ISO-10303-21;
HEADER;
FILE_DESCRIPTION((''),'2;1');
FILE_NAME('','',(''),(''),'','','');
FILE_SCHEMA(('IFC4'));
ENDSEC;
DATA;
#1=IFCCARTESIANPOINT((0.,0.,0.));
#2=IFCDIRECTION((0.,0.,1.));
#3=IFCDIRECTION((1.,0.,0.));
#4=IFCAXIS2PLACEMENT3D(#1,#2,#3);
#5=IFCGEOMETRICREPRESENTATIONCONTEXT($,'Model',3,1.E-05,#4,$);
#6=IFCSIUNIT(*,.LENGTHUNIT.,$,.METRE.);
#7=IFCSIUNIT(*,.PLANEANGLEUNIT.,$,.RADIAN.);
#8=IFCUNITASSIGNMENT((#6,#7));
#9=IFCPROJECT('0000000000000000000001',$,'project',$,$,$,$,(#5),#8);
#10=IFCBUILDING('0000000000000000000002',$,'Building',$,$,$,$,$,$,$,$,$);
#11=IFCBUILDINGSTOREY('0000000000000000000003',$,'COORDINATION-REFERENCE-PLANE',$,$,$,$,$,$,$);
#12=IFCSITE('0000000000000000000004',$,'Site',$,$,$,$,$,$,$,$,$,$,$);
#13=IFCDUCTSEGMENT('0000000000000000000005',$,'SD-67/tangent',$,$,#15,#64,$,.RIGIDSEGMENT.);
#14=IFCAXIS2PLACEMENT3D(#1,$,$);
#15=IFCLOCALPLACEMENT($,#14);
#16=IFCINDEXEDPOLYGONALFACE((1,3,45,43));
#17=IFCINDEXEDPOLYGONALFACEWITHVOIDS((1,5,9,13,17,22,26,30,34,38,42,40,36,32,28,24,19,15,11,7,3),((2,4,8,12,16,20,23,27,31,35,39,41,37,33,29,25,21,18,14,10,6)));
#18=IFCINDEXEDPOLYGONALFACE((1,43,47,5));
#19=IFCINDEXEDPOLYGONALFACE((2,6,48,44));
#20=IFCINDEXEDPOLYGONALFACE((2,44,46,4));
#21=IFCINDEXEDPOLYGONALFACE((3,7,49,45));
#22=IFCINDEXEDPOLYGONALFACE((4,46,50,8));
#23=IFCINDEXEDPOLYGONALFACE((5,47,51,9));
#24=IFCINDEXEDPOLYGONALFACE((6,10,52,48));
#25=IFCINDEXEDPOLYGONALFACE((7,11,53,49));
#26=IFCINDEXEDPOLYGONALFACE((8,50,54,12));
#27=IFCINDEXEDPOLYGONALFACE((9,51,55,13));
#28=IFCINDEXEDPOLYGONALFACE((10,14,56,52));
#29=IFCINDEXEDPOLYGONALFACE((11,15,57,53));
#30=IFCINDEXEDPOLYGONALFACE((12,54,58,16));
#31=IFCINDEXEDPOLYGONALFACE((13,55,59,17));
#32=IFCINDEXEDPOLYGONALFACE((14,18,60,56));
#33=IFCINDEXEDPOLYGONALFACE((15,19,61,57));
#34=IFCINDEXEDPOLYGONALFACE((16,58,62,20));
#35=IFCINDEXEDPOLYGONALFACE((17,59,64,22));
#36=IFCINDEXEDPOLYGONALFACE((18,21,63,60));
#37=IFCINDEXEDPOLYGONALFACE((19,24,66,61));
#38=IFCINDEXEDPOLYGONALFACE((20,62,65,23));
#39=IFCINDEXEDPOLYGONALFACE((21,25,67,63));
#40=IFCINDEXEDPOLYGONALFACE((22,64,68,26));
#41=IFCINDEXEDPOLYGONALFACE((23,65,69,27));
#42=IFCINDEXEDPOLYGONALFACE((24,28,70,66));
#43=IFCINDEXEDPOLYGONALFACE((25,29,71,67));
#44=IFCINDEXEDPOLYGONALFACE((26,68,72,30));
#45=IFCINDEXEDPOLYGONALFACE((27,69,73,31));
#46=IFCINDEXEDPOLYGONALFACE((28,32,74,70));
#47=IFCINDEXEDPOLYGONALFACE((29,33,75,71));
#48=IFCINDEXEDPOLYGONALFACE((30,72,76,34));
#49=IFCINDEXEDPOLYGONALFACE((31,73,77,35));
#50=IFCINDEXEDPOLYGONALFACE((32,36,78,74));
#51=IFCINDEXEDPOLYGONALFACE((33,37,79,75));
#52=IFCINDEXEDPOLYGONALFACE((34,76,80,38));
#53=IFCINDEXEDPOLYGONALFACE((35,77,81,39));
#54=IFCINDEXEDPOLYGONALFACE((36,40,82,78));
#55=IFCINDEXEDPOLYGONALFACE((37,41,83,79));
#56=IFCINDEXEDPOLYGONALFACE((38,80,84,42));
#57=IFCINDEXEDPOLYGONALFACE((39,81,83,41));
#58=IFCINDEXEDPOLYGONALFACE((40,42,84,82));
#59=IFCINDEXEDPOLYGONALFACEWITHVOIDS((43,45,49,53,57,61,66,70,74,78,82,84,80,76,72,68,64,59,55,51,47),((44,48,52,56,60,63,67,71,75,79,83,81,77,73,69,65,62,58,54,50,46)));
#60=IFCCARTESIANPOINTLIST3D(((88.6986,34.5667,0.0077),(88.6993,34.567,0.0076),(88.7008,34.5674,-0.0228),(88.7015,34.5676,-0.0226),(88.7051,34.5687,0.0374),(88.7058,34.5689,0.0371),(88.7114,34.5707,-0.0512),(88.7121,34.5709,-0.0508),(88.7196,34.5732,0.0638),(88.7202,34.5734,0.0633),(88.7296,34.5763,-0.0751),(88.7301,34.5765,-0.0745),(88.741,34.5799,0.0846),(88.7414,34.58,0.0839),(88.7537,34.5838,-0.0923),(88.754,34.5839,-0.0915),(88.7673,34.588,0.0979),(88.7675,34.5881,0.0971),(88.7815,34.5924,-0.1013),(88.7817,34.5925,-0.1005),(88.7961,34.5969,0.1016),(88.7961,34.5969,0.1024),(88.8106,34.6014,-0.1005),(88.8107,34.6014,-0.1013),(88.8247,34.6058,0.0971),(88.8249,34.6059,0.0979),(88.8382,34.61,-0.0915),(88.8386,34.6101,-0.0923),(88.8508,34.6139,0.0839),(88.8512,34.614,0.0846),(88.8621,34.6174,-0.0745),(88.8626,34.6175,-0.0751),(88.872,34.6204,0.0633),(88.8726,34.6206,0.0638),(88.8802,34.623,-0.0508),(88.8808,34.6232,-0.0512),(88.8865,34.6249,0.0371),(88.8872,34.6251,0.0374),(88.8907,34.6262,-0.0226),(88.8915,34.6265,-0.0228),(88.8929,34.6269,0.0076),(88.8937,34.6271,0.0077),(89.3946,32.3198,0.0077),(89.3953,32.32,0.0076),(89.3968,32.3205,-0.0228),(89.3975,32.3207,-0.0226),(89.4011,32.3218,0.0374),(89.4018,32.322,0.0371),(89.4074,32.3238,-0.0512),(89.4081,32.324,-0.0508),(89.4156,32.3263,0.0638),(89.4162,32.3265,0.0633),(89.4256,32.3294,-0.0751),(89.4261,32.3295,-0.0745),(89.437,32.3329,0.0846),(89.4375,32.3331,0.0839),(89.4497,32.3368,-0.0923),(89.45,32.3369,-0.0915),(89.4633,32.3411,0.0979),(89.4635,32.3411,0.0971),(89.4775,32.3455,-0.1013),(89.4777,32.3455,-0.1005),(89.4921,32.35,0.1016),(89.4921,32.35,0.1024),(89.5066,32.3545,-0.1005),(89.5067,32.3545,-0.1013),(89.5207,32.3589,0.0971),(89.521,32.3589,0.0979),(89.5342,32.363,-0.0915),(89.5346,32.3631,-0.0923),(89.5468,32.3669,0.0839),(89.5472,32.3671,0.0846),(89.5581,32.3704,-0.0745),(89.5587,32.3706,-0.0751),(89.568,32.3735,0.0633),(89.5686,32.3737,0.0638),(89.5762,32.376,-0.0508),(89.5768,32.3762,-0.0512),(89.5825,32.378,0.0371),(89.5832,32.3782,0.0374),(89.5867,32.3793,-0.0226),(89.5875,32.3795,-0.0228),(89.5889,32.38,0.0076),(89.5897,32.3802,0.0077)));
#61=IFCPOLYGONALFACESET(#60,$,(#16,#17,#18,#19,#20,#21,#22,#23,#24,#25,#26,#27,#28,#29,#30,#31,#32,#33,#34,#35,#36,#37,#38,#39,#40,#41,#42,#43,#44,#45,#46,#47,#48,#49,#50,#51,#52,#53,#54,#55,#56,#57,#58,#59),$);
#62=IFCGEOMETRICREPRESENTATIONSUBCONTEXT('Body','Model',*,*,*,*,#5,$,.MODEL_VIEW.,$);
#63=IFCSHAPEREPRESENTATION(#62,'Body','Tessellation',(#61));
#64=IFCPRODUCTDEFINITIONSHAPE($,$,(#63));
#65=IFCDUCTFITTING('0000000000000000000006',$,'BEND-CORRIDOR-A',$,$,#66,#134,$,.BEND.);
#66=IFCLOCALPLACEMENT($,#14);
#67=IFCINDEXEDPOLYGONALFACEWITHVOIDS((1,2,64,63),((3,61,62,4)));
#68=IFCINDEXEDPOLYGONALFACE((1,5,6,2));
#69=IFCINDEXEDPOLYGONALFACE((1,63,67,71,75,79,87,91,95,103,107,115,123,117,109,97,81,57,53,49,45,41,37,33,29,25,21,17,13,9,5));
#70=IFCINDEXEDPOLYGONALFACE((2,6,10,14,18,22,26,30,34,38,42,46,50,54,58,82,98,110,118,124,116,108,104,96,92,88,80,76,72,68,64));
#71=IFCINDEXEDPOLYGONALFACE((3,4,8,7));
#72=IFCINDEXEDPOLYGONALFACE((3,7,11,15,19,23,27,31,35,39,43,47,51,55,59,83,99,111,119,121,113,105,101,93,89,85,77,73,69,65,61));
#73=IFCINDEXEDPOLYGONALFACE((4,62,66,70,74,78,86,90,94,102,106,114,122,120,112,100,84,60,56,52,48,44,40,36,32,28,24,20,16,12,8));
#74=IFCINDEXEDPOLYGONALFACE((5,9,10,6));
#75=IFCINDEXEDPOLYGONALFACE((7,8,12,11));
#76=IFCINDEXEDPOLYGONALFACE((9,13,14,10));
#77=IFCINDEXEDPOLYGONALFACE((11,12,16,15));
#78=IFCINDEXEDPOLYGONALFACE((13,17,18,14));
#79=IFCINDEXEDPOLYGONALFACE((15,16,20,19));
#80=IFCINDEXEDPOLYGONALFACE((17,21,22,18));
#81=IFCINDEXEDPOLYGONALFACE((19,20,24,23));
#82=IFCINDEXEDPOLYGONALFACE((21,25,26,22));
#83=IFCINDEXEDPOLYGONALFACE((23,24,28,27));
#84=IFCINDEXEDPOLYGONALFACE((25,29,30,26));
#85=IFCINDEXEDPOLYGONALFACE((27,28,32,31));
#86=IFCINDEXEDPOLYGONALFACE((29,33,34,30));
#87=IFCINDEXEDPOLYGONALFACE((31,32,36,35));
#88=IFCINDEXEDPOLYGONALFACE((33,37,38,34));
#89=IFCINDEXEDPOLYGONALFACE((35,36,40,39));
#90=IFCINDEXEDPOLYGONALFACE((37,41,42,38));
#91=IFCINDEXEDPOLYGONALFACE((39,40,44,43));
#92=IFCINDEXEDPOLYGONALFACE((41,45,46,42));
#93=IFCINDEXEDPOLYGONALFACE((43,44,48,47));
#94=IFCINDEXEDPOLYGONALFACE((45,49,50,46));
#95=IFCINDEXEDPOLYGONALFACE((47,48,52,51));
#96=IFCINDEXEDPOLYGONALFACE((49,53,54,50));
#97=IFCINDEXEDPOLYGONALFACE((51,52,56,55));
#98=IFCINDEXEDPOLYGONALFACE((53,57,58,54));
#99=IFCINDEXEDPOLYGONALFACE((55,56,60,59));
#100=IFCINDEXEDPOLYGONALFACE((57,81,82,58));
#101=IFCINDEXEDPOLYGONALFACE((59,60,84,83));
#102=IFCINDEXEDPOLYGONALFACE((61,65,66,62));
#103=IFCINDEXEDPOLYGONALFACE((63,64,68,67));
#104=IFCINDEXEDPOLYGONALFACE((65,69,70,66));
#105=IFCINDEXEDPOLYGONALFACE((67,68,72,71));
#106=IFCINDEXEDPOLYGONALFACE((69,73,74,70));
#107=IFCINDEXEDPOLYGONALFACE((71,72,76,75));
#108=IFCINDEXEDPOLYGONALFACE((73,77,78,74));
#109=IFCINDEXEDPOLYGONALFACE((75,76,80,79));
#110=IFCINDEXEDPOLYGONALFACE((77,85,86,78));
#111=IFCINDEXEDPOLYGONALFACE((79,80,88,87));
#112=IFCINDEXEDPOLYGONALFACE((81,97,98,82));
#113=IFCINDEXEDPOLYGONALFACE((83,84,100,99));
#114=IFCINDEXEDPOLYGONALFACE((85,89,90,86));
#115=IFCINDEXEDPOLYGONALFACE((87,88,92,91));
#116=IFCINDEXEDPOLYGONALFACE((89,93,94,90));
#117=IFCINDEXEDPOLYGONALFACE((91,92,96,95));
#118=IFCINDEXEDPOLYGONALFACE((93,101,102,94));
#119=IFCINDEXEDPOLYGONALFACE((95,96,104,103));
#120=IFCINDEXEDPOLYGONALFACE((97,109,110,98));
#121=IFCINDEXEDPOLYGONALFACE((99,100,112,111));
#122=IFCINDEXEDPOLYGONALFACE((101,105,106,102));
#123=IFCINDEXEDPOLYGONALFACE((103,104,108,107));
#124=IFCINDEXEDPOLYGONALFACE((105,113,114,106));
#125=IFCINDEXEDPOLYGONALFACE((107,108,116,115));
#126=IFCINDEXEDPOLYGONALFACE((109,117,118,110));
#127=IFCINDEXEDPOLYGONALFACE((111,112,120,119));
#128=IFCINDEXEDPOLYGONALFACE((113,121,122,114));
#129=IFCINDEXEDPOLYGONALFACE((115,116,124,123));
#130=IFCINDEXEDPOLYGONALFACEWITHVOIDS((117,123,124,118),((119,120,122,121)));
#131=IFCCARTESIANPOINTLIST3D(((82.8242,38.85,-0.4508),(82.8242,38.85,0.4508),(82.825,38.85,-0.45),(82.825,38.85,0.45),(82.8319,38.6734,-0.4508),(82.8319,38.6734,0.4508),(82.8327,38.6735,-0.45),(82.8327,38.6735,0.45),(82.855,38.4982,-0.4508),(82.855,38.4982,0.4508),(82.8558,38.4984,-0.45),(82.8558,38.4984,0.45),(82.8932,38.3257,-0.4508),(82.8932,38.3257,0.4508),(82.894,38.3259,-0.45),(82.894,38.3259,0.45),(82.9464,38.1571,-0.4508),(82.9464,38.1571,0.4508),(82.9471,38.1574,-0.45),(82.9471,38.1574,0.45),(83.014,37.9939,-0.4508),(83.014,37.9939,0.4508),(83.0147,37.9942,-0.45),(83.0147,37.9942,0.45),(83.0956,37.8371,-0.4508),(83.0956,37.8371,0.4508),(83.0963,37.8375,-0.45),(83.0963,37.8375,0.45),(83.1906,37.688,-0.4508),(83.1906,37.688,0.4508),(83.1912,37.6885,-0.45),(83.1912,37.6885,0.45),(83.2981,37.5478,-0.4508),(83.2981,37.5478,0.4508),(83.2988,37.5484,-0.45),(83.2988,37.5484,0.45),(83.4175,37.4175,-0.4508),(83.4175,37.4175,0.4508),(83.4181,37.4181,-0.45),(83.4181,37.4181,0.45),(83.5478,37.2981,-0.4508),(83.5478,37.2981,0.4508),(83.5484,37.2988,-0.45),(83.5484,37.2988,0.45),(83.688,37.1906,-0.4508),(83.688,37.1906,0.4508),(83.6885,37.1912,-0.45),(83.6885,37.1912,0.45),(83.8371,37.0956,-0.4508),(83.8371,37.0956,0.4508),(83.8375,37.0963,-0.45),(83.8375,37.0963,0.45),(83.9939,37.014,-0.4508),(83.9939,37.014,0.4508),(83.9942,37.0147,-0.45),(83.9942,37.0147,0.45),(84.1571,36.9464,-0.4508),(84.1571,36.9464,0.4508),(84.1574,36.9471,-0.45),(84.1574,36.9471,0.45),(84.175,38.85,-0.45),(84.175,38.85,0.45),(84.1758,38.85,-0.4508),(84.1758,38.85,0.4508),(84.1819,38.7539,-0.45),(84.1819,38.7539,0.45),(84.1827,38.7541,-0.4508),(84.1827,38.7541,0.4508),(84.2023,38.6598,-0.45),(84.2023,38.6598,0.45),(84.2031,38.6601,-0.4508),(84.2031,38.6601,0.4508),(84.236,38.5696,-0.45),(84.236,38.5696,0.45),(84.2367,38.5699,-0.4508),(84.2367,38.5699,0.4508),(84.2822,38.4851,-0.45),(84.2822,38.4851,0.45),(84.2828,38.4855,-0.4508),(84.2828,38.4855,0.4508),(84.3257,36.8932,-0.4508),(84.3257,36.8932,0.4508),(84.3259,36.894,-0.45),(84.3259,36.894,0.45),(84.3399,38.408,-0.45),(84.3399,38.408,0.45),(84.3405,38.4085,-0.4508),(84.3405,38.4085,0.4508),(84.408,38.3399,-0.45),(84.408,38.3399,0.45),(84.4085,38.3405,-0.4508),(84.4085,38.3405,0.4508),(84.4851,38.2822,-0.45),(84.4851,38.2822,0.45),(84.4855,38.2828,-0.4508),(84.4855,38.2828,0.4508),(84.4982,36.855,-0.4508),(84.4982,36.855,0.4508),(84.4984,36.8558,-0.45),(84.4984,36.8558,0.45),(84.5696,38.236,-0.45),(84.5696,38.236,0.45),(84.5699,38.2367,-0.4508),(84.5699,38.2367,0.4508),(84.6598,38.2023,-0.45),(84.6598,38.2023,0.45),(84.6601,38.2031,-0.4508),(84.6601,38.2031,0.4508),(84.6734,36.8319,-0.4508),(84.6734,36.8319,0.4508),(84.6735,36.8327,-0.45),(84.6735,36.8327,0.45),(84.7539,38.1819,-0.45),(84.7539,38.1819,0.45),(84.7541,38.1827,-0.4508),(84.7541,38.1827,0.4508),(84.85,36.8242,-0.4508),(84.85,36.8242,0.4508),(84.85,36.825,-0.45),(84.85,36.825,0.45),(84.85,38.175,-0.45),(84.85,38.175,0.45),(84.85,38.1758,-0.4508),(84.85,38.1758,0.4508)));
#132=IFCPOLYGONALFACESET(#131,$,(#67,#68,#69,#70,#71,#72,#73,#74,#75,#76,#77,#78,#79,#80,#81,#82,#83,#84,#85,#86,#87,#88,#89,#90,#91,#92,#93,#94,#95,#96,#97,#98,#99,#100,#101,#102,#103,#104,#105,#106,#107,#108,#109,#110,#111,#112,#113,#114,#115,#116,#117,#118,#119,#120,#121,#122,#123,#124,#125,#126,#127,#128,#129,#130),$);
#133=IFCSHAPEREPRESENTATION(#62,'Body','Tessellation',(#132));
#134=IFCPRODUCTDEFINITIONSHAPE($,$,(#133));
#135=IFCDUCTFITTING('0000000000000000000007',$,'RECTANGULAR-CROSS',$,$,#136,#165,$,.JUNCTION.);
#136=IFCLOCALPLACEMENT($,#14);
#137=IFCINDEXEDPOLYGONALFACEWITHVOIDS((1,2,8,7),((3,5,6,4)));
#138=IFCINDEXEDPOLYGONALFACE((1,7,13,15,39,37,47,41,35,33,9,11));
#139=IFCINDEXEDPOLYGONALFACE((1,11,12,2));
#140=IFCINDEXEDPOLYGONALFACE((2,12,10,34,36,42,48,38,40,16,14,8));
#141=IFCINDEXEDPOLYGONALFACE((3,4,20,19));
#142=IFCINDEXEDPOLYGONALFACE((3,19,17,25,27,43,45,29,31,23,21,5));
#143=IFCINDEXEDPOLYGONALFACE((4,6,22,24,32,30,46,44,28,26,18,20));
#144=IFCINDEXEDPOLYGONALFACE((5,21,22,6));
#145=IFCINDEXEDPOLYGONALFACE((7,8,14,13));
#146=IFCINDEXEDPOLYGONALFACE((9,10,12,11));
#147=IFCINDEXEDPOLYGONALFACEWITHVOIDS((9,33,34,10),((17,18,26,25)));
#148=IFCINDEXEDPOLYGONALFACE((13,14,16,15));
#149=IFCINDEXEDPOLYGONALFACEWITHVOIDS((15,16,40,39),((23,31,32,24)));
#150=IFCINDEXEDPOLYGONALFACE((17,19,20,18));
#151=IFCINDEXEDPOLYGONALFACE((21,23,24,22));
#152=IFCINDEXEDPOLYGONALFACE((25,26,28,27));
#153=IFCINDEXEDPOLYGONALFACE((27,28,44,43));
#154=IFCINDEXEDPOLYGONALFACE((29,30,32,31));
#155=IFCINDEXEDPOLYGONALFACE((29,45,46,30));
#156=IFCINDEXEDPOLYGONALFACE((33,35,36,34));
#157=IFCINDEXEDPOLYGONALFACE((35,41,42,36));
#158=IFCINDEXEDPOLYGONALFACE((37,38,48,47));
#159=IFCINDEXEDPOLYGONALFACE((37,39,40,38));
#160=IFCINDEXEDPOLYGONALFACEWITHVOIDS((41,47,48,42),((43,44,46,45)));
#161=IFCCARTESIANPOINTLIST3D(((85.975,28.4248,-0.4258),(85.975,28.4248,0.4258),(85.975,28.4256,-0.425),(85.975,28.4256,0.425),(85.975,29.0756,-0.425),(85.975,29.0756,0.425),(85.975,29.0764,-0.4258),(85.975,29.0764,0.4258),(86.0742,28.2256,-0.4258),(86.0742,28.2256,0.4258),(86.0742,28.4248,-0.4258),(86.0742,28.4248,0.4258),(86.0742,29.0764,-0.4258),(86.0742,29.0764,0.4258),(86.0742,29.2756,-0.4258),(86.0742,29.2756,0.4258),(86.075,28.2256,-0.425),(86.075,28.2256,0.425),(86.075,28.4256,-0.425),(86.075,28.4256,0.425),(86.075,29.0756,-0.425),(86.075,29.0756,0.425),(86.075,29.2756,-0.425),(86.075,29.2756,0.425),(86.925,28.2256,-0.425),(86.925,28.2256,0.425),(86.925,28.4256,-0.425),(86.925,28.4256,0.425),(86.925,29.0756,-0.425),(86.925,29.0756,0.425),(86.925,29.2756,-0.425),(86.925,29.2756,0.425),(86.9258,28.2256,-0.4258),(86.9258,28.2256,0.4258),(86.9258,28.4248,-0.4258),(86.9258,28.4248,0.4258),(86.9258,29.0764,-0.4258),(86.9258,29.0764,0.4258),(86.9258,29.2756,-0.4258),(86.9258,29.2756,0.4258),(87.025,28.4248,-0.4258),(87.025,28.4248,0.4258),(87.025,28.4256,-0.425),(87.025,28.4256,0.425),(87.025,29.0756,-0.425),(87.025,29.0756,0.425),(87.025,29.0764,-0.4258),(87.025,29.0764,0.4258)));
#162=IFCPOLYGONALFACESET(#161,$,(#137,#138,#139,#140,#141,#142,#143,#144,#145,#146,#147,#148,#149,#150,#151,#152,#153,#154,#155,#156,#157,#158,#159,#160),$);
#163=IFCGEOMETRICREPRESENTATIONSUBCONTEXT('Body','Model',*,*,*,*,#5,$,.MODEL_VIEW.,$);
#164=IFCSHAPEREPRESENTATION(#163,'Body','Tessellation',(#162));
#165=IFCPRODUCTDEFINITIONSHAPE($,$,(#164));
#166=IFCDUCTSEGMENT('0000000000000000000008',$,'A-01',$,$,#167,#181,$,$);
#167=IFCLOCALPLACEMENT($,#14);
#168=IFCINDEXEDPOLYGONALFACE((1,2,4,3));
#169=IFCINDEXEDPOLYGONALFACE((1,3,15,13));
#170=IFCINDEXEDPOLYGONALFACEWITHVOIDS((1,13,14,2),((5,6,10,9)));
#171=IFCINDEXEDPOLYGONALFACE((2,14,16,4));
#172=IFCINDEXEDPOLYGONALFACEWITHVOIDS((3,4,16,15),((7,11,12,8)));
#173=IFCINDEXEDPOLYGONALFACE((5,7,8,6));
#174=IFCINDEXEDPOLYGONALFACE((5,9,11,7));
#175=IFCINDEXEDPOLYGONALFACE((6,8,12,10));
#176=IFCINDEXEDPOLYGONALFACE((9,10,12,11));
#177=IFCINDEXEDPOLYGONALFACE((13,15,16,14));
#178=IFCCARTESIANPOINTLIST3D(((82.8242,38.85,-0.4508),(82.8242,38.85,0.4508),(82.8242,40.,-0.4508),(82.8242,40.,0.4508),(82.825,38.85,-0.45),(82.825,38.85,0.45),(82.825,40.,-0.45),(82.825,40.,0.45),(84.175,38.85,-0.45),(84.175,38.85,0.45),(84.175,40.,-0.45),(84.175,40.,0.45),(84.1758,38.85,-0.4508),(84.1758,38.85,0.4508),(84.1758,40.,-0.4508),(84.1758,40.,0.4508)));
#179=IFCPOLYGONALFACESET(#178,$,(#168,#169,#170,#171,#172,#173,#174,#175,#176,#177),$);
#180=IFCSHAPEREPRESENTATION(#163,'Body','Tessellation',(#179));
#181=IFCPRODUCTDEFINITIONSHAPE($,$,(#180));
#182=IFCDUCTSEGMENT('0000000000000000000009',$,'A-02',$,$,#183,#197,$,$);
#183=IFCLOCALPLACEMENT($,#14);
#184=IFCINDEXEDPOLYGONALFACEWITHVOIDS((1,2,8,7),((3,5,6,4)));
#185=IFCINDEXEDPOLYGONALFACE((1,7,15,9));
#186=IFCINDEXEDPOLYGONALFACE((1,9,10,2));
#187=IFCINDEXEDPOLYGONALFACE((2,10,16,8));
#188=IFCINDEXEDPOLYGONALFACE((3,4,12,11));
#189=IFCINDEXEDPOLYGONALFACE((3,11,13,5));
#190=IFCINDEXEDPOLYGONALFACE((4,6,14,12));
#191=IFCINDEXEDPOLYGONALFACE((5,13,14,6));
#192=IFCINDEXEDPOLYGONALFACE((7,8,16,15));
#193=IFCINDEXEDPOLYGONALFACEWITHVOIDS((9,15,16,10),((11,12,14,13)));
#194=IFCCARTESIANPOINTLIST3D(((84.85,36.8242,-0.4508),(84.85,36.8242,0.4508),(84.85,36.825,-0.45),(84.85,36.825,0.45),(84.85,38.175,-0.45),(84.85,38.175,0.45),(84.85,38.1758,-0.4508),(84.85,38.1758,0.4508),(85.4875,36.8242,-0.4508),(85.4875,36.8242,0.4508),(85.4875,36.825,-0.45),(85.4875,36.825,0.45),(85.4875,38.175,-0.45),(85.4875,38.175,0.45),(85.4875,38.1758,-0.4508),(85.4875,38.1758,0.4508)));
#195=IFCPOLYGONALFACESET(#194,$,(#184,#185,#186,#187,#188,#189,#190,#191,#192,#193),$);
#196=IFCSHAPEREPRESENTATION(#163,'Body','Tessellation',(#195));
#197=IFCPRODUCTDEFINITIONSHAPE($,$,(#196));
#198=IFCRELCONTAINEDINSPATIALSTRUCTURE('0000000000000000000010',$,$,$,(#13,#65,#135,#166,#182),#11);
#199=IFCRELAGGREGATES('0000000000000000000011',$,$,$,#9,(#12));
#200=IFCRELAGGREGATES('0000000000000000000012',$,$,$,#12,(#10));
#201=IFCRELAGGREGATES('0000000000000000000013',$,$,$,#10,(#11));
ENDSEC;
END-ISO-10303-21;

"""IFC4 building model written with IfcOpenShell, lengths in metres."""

from ifc_helpers import new_model, entity, si_unit, frame, origin, origin_with_axes, place, context, subcontext, project, spatial, rectangle, hollow_rectangle, hollow_circle, extrude, boolean, element, save


model = new_model("IFC4")

# Units and contexts
model_context = context("Model", 3, precision=1e-05, world=origin_with_axes())
body_context_1 = subcontext(model_context, "Body", "Model", "MODEL_VIEW")
body_context_2 = subcontext(model_context, "Body", "Model", "MODEL_VIEW")
ifc_project = project(units=[si_unit("LENGTHUNIT", "METRE"), si_unit("PLANEANGLEUNIT", "RADIAN")], contexts=[model_context])

# Site, building, storey
site = spatial("IfcSite", under=ifc_project, Name="Site")
building = spatial("IfcBuilding", under=site, Name="Building")
storey = spatial("IfcBuildingStorey", under=building, Name="COORDINATION-REFERENCE-PLANE")

# Duct segment
duct_segment_1_placement = place(None, frame((89.4921, 32.35, 0.0), z_axis=(-0.295887, 0.955223, 0.0), x_axis=(0.0, 0.0, 1.0)))
element("IfcDuctSegment", 1, at=duct_segment_1_placement, inside=storey, Name="SD-67/tangent", PredefinedType="RIGIDSEGMENT", context=body_context_1, shape_type="SweptSolid", body=[
    extrude(hollow_circle(Radius=0.1024, WallThickness=0.0008), origin_with_axes(), (0.0, 0.0, 1.0), 2.3523),
])

# Duct fittings
duct_fitting_1_placement = place(None, frame((84.85, 38.85, 0.0), z_axis=(0.0, 0.0, 1.0), x_axis=(-1.0, 0.0, 0.0)))
cartesian_point_1 = entity("IfcCartesianPoint", [0.0, 0.0, 0.0])
element("IfcDuctFitting", 2, at=duct_fitting_1_placement, inside=storey, Name="BEND-CORRIDOR-A", PredefinedType="BEND", context=body_context_1, shape_type="SweptSolid", body=[
    entity("IfcRevolvedAreaSolid", entity("IfcRectangleHollowProfileDef", "AREA", None, entity("IfcAxis2Placement2D", entity("IfcCartesianPoint", [1.35, 0.0])), 1.3516, 0.9016, 0.0008), entity("IfcAxis2Placement3D", cartesian_point_1, entity("IfcDirection", [0.0, -1.0, 0.0]), entity("IfcDirection", [1.0, 0.0, 0.0])), entity("IfcAxis1Placement", cartesian_point_1, entity("IfcDirection", [0.0, 1.0, 0.0])), 1.570796),
])
duct_fitting_2_placement = place(None, frame((86.5, 28.7506, 0.0), z_axis=(0.0, -1.0, 0.0), x_axis=(1.0, 0.0, 0.0)))
solid = boolean("UNION", extrude(rectangle(XDim=0.85, YDim=0.85), frame((0.0, 0.0, -0.525), z_axis=(0.0, 0.0, 1.0), x_axis=(1.0, 0.0, 0.0)), (0.0, 0.0, 1.0), 1.05), extrude(rectangle(XDim=0.65, YDim=0.85), frame((-0.525, 0.0, 0.0), z_axis=(1.0, 0.0, 0.0), x_axis=(0.0, 0.0, -1.0)), (0.0, 0.0, 1.0), 1.05))
element("IfcDuctFitting", 3, at=duct_fitting_2_placement, inside=storey, Name="RECTANGULAR-CROSS", PredefinedType="JUNCTION", context=body_context_2, shape_type="CSG", body=[
    boolean("DIFFERENCE", boolean("UNION", extrude(rectangle(XDim=0.8516, YDim=0.8516), frame((0.0, 0.0, -0.525), z_axis=(0.0, 0.0, 1.0), x_axis=(1.0, 0.0, 0.0)), (0.0, 0.0, 1.0), 1.05), extrude(rectangle(XDim=0.6516, YDim=0.8516), frame((-0.525, 0.0, 0.0), z_axis=(1.0, 0.0, 0.0), x_axis=(0.0, 0.0, -1.0)), (0.0, 0.0, 1.0), 1.05)), solid),
])

# Duct segments
duct_segment_2_placement = place(None, frame((83.5, 38.85, 0.0), z_axis=(0.0, 1.0, 0.0), x_axis=(1.0, 0.0, 0.0)))
element("IfcDuctSegment", 4, at=duct_segment_2_placement, inside=storey, Name="A-01", context=body_context_2, shape_type="SweptSolid", body=[
    extrude(hollow_rectangle(XDim=1.3516, YDim=0.9016, WallThickness=0.0008), origin(), (0.0, 0.0, 1.0), 1.15),
])
duct_segment_3_placement = place(None, frame((84.85, 37.5, 0.0), z_axis=(1.0, 0.0, 0.0), x_axis=(0.0, 1.0, 0.0)))
element("IfcDuctSegment", 5, at=duct_segment_3_placement, inside=storey, Name="A-02", context=body_context_2, shape_type="SweptSolid", body=[
    extrude(hollow_rectangle(XDim=1.3516, YDim=0.9016, WallThickness=0.0008), origin(), (0.0, 0.0, 1.0), 0.6375),
])

save(model, "model.ifc")
